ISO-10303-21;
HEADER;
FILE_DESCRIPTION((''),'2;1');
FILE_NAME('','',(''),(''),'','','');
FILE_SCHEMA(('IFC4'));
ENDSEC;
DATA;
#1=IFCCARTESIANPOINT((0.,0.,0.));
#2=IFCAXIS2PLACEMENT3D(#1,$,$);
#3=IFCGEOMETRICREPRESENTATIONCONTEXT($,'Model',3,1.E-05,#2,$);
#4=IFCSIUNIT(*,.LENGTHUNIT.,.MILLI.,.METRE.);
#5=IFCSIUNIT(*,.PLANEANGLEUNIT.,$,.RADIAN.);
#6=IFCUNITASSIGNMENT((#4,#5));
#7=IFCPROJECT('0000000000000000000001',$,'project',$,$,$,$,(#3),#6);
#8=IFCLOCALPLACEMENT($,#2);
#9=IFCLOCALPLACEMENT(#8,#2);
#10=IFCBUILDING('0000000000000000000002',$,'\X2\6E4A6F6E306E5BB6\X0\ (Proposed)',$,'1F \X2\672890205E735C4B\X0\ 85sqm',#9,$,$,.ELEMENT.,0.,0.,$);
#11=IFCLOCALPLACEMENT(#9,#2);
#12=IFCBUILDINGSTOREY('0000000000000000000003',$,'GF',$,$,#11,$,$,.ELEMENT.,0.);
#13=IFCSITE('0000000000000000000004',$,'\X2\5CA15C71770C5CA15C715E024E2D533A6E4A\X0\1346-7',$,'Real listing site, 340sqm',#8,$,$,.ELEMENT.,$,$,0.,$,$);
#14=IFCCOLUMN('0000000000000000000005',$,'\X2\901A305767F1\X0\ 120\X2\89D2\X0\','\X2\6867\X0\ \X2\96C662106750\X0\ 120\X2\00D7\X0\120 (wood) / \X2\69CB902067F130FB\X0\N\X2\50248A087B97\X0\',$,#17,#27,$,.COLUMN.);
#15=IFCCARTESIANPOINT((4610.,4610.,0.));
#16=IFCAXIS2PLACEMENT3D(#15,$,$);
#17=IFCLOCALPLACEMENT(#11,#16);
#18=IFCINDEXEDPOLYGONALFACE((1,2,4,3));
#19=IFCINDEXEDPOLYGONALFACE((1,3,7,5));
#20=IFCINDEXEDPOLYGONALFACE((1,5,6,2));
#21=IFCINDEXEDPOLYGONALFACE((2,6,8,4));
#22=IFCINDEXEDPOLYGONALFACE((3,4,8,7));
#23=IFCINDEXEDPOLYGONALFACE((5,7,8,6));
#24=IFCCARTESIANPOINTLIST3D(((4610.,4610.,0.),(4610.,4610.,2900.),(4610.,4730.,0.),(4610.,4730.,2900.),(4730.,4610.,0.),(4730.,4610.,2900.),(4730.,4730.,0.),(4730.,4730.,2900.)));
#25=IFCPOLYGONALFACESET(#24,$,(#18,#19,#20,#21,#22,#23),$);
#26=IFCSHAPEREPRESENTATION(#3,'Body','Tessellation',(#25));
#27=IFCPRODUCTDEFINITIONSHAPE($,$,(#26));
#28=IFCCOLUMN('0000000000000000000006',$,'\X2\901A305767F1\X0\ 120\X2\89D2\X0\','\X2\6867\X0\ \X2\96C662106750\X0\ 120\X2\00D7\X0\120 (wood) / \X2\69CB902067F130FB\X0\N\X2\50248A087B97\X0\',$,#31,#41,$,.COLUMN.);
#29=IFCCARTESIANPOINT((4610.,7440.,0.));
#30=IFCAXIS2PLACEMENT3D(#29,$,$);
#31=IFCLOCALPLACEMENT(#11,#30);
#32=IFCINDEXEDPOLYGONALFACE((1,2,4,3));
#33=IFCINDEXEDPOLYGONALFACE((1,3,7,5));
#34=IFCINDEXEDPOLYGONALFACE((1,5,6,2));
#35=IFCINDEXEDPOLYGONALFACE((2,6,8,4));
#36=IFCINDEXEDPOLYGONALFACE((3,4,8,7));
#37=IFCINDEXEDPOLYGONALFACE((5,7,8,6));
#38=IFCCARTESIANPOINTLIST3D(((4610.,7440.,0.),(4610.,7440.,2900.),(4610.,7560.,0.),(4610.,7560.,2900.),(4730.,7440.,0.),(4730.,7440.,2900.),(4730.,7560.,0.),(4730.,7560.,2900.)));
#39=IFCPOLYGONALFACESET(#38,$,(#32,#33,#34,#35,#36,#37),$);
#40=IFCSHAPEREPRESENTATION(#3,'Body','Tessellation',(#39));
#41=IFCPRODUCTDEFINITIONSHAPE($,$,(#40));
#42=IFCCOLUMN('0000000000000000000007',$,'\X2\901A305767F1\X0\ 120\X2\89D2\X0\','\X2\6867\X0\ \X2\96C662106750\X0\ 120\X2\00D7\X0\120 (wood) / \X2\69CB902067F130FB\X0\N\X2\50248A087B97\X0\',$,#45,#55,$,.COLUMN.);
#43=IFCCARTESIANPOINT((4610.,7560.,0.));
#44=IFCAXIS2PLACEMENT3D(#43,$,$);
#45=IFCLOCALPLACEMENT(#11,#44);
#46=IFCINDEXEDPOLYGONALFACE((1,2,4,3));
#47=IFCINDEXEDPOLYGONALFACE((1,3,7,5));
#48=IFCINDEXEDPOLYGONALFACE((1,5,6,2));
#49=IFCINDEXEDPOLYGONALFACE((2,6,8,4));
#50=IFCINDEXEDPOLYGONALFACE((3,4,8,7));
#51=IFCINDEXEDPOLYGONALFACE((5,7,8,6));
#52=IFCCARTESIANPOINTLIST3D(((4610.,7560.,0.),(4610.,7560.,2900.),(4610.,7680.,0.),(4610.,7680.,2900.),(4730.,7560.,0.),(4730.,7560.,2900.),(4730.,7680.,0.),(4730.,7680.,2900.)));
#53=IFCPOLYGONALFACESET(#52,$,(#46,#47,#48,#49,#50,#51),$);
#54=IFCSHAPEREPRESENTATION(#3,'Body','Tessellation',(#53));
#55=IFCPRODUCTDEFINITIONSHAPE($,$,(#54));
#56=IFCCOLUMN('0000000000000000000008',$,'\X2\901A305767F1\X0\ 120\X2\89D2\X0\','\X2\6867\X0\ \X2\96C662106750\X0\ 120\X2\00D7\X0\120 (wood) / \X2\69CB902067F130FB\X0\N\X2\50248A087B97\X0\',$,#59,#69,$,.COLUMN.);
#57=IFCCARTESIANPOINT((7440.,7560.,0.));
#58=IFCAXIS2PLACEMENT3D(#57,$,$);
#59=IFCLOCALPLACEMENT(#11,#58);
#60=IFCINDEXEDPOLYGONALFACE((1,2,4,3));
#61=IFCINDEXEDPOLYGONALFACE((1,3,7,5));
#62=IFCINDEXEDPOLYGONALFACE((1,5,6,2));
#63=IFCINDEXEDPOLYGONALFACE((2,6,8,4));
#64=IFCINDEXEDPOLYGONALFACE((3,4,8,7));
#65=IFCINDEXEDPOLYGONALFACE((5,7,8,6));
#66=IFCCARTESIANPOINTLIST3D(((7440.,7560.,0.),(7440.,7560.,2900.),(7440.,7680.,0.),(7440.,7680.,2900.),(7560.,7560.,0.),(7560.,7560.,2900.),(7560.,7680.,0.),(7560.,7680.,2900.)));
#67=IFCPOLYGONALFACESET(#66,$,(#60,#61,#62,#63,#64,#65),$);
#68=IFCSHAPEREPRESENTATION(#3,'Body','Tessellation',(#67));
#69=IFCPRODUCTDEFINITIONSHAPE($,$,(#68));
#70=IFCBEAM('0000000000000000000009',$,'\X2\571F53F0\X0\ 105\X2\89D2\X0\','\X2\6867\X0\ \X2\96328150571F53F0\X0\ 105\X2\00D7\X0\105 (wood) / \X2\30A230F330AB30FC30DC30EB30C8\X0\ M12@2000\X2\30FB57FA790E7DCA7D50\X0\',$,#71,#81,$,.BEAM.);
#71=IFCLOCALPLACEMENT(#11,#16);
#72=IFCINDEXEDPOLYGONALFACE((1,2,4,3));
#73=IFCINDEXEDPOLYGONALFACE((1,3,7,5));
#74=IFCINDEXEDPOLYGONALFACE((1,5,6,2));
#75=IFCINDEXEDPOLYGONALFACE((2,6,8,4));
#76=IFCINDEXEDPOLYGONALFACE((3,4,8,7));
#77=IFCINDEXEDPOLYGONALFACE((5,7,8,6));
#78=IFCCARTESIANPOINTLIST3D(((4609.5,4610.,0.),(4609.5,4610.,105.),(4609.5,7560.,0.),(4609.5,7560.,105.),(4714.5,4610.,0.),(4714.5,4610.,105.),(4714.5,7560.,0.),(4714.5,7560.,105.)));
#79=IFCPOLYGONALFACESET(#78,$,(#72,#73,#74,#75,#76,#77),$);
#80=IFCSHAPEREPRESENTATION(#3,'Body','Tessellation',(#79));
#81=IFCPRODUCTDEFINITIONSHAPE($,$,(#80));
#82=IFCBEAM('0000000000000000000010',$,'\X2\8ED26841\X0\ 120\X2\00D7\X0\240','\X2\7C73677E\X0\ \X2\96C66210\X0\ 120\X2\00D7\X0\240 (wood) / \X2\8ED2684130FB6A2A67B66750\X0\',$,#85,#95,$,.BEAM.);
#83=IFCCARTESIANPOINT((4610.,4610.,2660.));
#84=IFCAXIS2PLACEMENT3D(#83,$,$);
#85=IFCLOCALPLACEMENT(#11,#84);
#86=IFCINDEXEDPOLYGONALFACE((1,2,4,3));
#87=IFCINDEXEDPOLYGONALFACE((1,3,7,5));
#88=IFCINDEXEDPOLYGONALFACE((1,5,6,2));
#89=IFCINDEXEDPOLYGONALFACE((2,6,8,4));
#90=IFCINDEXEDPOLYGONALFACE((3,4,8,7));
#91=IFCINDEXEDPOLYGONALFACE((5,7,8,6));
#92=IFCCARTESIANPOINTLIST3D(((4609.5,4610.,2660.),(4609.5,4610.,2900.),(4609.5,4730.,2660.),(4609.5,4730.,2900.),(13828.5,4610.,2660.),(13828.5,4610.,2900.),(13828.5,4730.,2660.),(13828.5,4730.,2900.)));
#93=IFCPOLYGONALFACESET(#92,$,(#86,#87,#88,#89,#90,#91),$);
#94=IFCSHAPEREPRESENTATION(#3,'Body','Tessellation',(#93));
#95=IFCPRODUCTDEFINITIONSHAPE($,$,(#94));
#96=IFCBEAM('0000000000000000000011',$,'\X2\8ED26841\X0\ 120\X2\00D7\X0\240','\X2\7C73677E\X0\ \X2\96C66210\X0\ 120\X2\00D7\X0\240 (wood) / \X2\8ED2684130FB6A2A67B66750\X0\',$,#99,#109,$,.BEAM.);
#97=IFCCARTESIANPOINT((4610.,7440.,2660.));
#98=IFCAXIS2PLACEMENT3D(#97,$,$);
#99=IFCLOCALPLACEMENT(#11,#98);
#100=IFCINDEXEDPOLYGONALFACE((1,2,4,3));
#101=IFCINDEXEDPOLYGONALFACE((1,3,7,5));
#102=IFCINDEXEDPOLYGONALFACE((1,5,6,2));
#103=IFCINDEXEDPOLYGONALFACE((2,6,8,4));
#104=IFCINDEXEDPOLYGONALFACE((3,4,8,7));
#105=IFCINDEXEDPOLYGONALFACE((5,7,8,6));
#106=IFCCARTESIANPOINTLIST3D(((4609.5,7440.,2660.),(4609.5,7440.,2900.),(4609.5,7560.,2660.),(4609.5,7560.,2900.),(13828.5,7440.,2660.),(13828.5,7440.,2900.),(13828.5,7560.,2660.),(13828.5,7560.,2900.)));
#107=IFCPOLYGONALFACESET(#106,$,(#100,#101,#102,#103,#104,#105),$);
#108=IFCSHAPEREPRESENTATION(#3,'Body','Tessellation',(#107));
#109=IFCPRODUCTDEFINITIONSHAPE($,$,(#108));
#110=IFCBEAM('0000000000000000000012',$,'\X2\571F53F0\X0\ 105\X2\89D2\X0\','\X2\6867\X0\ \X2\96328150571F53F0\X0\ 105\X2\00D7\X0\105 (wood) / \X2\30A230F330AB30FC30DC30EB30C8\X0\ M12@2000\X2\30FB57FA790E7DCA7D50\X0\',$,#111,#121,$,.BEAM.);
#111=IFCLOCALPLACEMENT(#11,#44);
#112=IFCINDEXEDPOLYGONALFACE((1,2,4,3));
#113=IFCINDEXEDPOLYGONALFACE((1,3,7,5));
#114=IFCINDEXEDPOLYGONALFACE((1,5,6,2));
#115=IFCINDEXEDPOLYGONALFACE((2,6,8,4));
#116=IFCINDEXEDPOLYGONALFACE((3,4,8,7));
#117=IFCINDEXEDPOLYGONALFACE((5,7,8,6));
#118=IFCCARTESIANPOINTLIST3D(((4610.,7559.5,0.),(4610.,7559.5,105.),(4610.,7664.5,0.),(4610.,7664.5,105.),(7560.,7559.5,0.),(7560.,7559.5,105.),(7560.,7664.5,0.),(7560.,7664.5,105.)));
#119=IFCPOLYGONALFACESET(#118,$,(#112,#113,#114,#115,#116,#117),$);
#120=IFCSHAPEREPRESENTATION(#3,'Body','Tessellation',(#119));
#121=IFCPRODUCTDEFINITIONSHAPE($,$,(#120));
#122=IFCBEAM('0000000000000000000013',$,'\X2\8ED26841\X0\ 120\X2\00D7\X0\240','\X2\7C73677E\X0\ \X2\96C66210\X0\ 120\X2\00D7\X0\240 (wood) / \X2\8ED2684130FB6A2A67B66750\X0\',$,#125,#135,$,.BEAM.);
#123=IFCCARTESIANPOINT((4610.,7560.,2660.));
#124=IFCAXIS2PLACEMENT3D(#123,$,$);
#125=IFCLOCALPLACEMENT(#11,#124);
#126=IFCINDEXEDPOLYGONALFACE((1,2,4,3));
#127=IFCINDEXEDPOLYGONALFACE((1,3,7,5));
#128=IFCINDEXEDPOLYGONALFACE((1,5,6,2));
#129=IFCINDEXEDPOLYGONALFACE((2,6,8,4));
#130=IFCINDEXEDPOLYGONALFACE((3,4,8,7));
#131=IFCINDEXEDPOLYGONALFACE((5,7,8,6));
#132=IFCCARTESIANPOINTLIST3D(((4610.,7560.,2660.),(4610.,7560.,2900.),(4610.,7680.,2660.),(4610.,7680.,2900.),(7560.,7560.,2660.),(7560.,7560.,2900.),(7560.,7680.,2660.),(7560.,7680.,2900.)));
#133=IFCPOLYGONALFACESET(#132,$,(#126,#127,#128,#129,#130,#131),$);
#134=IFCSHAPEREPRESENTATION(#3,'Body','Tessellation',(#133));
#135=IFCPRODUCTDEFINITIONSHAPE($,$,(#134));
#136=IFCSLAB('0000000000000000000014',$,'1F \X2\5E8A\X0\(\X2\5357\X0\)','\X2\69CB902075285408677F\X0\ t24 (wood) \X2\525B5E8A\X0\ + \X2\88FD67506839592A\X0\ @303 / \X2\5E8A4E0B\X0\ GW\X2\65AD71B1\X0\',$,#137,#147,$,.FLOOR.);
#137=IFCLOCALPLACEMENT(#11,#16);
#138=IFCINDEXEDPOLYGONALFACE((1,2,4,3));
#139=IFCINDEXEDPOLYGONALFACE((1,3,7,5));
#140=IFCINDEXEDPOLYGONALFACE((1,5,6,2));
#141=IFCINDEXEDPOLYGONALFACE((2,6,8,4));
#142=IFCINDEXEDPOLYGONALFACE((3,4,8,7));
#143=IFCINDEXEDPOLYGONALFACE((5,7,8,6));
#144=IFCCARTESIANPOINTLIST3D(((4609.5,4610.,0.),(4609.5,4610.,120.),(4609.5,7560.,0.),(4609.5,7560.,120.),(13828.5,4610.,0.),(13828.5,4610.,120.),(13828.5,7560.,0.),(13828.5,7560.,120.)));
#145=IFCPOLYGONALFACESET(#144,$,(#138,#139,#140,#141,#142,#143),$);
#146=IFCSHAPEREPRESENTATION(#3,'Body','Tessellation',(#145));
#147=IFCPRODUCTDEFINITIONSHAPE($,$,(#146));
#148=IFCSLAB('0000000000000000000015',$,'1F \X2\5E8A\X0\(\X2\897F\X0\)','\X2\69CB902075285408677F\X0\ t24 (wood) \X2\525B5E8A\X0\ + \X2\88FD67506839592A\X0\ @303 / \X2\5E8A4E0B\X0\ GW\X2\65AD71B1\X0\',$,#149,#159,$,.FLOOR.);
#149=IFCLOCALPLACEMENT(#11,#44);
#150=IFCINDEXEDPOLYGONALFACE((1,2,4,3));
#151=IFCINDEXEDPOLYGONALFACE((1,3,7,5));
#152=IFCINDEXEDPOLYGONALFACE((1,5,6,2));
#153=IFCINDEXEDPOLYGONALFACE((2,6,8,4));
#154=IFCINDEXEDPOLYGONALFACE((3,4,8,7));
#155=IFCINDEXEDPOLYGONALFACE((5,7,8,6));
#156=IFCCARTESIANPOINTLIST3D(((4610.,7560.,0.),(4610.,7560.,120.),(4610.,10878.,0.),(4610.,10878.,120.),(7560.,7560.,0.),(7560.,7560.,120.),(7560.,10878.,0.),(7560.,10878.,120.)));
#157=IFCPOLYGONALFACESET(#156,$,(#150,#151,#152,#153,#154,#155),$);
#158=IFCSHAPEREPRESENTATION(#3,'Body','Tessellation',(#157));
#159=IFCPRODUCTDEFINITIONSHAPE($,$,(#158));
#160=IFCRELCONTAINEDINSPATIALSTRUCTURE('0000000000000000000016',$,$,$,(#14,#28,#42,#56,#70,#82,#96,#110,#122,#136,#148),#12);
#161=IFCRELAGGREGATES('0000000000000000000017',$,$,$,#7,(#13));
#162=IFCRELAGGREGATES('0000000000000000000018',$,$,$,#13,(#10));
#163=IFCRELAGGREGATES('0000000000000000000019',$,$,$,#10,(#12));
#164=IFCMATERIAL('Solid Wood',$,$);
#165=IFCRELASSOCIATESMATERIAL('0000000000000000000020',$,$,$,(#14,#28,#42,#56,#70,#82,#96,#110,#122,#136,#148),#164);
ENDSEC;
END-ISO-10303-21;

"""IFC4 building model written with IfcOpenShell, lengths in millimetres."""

from ifc_helpers import new_model, si_unit, frame, frame_2d, origin, place, context, project, spatial, rectangle, extrude, material, element, save


model = new_model("IFC4")

# Units and contexts
model_context = context("Model", 3, precision=1e-05, world=origin())
ifc_project = project(units=[si_unit("LENGTHUNIT", "METRE", prefix="MILLI"), si_unit("PLANEANGLEUNIT", "RADIAN")], contexts=[model_context])

# Site, building, storey
site_placement = place(None, origin())
site = spatial("IfcSite", under=ifc_project, at=site_placement, Name="岡山県岡山市中区湊1346-7", ObjectType="Real listing site, 340sqm", CompositionType="ELEMENT", RefElevation=0.0)
building_placement = place(site_placement, origin())
building = spatial("IfcBuilding", under=site, at=building_placement, Name="湊潮の家 (Proposed)", ObjectType="1F 木造平屋 85sqm", CompositionType="ELEMENT", ElevationOfRefHeight=0.0, ElevationOfTerrain=0.0)
storey_placement = place(building_placement, origin())
storey = spatial("IfcBuildingStorey", under=building, at=storey_placement, Name="GF", CompositionType="ELEMENT", Elevation=0.0)

# Columns
ifc_material_1 = material(Name="Solid Wood")
column_1_placement = place(storey_placement, frame((4610.0, 4610.0, 0.0)))
element("IfcColumn", 1, at=column_1_placement, inside=storey, material=ifc_material_1, Name="通し柱 120角", Description="桧 集成材 120×120 (wood) / 構造柱・N値計算", PredefinedType="COLUMN", context=model_context, shape_type="SweptSolid", body=[
    extrude(rectangle(XDim=120.0, YDim=120.0, at=frame_2d((60.0, 60.0))), frame((4610.0, 4610.0, 0.0)), (0.0, 0.0, 1.0), 2900.0),
])
column_2_placement = place(storey_placement, frame((4610.0, 7440.0, 0.0)))
element("IfcColumn", 2, at=column_2_placement, inside=storey, material=ifc_material_1, Name="通し柱 120角", Description="桧 集成材 120×120 (wood) / 構造柱・N値計算", PredefinedType="COLUMN", context=model_context, shape_type="SweptSolid", body=[
    extrude(rectangle(XDim=120.0, YDim=120.0, at=frame_2d((60.0, 60.0))), frame((4610.0, 7440.0, 0.0)), (0.0, 0.0, 1.0), 2900.0),
])
column_3_placement = place(storey_placement, frame((4610.0, 7560.0, 0.0)))
element("IfcColumn", 3, at=column_3_placement, inside=storey, material=ifc_material_1, Name="通し柱 120角", Description="桧 集成材 120×120 (wood) / 構造柱・N値計算", PredefinedType="COLUMN", context=model_context, shape_type="SweptSolid", body=[
    extrude(rectangle(XDim=120.0, YDim=120.0, at=frame_2d((60.0, 60.0))), frame((4610.0, 7560.0, 0.0)), (0.0, 0.0, 1.0), 2900.0),
])
column_4_placement = place(storey_placement, frame((7440.0, 7560.0, 0.0)))
element("IfcColumn", 4, at=column_4_placement, inside=storey, material=ifc_material_1, Name="通し柱 120角", Description="桧 集成材 120×120 (wood) / 構造柱・N値計算", PredefinedType="COLUMN", context=model_context, shape_type="SweptSolid", body=[
    extrude(rectangle(XDim=120.0, YDim=120.0, at=frame_2d((60.0, 60.0))), frame((7440.0, 7560.0, 0.0)), (0.0, 0.0, 1.0), 2900.0),
])

# Beams
beam_1_placement = place(storey_placement, frame((4610.0, 4610.0, 0.0)))
element("IfcBeam", 5, at=beam_1_placement, inside=storey, material=ifc_material_1, Name="土台 105角", Description="桧 防腐土台 105×105 (wood) / アンカーボルト M12@2000・基礎緊結", PredefinedType="BEAM", context=model_context, shape_type="SweptSolid", body=[
    extrude(rectangle(XDim=105.0, YDim=2950.0, at=frame_2d((52.0, 1475.0))), frame((4610.0, 4610.0, 0.0)), (0.0, 0.0, 1.0), 105.0),
])
beam_2_placement = place(storey_placement, frame((4610.0, 4610.0, 2660.0)))
element("IfcBeam", 6, at=beam_2_placement, inside=storey, material=ifc_material_1, Name="軒桁 120×240", Description="米松 集成 120×240 (wood) / 軒桁・横架材", PredefinedType="BEAM", context=model_context, shape_type="SweptSolid", body=[
    extrude(rectangle(XDim=9219.0, YDim=120.0, at=frame_2d((4609.0, 60.0))), frame((4610.0, 4610.0, 2660.0)), (0.0, 0.0, 1.0), 240.0),
])
beam_3_placement = place(storey_placement, frame((4610.0, 7440.0, 2660.0)))
element("IfcBeam", 7, at=beam_3_placement, inside=storey, material=ifc_material_1, Name="軒桁 120×240", Description="米松 集成 120×240 (wood) / 軒桁・横架材", PredefinedType="BEAM", context=model_context, shape_type="SweptSolid", body=[
    extrude(rectangle(XDim=9219.0, YDim=120.0, at=frame_2d((4609.0, 60.0))), frame((4610.0, 7440.0, 2660.0)), (0.0, 0.0, 1.0), 240.0),
])
beam_4_placement = place(storey_placement, frame((4610.0, 7560.0, 0.0)))
element("IfcBeam", 8, at=beam_4_placement, inside=storey, material=ifc_material_1, Name="土台 105角", Description="桧 防腐土台 105×105 (wood) / アンカーボルト M12@2000・基礎緊結", PredefinedType="BEAM", context=model_context, shape_type="SweptSolid", body=[
    extrude(rectangle(XDim=2950.0, YDim=105.0, at=frame_2d((1475.0, 52.0))), frame((4610.0, 7560.0, 0.0)), (0.0, 0.0, 1.0), 105.0),
])
beam_5_placement = place(storey_placement, frame((4610.0, 7560.0, 2660.0)))
element("IfcBeam", 9, at=beam_5_placement, inside=storey, material=ifc_material_1, Name="軒桁 120×240", Description="米松 集成 120×240 (wood) / 軒桁・横架材", PredefinedType="BEAM", context=model_context, shape_type="SweptSolid", body=[
    extrude(rectangle(XDim=2950.0, YDim=120.0, at=frame_2d((1475.0, 60.0))), frame((4610.0, 7560.0, 2660.0)), (0.0, 0.0, 1.0), 240.0),
])

# Slabs
slab_1_placement = place(storey_placement, frame((4610.0, 4610.0, 0.0)))
element("IfcSlab", 10, at=slab_1_placement, inside=storey, material=ifc_material_1, Name="1F 床(南)", Description="構造用合板 t24 (wood) 剛床 + 製材根太 @303 / 床下 GW断熱", PredefinedType="FLOOR", context=model_context, shape_type="SweptSolid", body=[
    extrude(rectangle(XDim=9219.0, YDim=2950.0, at=frame_2d((4609.0, 1475.0))), frame((4610.0, 4610.0, 0.0)), (0.0, 0.0, 1.0), 120.0),
])
slab_2_placement = place(storey_placement, frame((4610.0, 7560.0, 0.0)))
element("IfcSlab", 11, at=slab_2_placement, inside=storey, material=ifc_material_1, Name="1F 床(西)", Description="構造用合板 t24 (wood) 剛床 + 製材根太 @303 / 床下 GW断熱", PredefinedType="FLOOR", context=model_context, shape_type="SweptSolid", body=[
    extrude(rectangle(XDim=2950.0, YDim=3318.0, at=frame_2d((1475.0, 1659.0))), frame((4610.0, 7560.0, 0.0)), (0.0, 0.0, 1.0), 120.0),
])

save(model, "model.ifc")
